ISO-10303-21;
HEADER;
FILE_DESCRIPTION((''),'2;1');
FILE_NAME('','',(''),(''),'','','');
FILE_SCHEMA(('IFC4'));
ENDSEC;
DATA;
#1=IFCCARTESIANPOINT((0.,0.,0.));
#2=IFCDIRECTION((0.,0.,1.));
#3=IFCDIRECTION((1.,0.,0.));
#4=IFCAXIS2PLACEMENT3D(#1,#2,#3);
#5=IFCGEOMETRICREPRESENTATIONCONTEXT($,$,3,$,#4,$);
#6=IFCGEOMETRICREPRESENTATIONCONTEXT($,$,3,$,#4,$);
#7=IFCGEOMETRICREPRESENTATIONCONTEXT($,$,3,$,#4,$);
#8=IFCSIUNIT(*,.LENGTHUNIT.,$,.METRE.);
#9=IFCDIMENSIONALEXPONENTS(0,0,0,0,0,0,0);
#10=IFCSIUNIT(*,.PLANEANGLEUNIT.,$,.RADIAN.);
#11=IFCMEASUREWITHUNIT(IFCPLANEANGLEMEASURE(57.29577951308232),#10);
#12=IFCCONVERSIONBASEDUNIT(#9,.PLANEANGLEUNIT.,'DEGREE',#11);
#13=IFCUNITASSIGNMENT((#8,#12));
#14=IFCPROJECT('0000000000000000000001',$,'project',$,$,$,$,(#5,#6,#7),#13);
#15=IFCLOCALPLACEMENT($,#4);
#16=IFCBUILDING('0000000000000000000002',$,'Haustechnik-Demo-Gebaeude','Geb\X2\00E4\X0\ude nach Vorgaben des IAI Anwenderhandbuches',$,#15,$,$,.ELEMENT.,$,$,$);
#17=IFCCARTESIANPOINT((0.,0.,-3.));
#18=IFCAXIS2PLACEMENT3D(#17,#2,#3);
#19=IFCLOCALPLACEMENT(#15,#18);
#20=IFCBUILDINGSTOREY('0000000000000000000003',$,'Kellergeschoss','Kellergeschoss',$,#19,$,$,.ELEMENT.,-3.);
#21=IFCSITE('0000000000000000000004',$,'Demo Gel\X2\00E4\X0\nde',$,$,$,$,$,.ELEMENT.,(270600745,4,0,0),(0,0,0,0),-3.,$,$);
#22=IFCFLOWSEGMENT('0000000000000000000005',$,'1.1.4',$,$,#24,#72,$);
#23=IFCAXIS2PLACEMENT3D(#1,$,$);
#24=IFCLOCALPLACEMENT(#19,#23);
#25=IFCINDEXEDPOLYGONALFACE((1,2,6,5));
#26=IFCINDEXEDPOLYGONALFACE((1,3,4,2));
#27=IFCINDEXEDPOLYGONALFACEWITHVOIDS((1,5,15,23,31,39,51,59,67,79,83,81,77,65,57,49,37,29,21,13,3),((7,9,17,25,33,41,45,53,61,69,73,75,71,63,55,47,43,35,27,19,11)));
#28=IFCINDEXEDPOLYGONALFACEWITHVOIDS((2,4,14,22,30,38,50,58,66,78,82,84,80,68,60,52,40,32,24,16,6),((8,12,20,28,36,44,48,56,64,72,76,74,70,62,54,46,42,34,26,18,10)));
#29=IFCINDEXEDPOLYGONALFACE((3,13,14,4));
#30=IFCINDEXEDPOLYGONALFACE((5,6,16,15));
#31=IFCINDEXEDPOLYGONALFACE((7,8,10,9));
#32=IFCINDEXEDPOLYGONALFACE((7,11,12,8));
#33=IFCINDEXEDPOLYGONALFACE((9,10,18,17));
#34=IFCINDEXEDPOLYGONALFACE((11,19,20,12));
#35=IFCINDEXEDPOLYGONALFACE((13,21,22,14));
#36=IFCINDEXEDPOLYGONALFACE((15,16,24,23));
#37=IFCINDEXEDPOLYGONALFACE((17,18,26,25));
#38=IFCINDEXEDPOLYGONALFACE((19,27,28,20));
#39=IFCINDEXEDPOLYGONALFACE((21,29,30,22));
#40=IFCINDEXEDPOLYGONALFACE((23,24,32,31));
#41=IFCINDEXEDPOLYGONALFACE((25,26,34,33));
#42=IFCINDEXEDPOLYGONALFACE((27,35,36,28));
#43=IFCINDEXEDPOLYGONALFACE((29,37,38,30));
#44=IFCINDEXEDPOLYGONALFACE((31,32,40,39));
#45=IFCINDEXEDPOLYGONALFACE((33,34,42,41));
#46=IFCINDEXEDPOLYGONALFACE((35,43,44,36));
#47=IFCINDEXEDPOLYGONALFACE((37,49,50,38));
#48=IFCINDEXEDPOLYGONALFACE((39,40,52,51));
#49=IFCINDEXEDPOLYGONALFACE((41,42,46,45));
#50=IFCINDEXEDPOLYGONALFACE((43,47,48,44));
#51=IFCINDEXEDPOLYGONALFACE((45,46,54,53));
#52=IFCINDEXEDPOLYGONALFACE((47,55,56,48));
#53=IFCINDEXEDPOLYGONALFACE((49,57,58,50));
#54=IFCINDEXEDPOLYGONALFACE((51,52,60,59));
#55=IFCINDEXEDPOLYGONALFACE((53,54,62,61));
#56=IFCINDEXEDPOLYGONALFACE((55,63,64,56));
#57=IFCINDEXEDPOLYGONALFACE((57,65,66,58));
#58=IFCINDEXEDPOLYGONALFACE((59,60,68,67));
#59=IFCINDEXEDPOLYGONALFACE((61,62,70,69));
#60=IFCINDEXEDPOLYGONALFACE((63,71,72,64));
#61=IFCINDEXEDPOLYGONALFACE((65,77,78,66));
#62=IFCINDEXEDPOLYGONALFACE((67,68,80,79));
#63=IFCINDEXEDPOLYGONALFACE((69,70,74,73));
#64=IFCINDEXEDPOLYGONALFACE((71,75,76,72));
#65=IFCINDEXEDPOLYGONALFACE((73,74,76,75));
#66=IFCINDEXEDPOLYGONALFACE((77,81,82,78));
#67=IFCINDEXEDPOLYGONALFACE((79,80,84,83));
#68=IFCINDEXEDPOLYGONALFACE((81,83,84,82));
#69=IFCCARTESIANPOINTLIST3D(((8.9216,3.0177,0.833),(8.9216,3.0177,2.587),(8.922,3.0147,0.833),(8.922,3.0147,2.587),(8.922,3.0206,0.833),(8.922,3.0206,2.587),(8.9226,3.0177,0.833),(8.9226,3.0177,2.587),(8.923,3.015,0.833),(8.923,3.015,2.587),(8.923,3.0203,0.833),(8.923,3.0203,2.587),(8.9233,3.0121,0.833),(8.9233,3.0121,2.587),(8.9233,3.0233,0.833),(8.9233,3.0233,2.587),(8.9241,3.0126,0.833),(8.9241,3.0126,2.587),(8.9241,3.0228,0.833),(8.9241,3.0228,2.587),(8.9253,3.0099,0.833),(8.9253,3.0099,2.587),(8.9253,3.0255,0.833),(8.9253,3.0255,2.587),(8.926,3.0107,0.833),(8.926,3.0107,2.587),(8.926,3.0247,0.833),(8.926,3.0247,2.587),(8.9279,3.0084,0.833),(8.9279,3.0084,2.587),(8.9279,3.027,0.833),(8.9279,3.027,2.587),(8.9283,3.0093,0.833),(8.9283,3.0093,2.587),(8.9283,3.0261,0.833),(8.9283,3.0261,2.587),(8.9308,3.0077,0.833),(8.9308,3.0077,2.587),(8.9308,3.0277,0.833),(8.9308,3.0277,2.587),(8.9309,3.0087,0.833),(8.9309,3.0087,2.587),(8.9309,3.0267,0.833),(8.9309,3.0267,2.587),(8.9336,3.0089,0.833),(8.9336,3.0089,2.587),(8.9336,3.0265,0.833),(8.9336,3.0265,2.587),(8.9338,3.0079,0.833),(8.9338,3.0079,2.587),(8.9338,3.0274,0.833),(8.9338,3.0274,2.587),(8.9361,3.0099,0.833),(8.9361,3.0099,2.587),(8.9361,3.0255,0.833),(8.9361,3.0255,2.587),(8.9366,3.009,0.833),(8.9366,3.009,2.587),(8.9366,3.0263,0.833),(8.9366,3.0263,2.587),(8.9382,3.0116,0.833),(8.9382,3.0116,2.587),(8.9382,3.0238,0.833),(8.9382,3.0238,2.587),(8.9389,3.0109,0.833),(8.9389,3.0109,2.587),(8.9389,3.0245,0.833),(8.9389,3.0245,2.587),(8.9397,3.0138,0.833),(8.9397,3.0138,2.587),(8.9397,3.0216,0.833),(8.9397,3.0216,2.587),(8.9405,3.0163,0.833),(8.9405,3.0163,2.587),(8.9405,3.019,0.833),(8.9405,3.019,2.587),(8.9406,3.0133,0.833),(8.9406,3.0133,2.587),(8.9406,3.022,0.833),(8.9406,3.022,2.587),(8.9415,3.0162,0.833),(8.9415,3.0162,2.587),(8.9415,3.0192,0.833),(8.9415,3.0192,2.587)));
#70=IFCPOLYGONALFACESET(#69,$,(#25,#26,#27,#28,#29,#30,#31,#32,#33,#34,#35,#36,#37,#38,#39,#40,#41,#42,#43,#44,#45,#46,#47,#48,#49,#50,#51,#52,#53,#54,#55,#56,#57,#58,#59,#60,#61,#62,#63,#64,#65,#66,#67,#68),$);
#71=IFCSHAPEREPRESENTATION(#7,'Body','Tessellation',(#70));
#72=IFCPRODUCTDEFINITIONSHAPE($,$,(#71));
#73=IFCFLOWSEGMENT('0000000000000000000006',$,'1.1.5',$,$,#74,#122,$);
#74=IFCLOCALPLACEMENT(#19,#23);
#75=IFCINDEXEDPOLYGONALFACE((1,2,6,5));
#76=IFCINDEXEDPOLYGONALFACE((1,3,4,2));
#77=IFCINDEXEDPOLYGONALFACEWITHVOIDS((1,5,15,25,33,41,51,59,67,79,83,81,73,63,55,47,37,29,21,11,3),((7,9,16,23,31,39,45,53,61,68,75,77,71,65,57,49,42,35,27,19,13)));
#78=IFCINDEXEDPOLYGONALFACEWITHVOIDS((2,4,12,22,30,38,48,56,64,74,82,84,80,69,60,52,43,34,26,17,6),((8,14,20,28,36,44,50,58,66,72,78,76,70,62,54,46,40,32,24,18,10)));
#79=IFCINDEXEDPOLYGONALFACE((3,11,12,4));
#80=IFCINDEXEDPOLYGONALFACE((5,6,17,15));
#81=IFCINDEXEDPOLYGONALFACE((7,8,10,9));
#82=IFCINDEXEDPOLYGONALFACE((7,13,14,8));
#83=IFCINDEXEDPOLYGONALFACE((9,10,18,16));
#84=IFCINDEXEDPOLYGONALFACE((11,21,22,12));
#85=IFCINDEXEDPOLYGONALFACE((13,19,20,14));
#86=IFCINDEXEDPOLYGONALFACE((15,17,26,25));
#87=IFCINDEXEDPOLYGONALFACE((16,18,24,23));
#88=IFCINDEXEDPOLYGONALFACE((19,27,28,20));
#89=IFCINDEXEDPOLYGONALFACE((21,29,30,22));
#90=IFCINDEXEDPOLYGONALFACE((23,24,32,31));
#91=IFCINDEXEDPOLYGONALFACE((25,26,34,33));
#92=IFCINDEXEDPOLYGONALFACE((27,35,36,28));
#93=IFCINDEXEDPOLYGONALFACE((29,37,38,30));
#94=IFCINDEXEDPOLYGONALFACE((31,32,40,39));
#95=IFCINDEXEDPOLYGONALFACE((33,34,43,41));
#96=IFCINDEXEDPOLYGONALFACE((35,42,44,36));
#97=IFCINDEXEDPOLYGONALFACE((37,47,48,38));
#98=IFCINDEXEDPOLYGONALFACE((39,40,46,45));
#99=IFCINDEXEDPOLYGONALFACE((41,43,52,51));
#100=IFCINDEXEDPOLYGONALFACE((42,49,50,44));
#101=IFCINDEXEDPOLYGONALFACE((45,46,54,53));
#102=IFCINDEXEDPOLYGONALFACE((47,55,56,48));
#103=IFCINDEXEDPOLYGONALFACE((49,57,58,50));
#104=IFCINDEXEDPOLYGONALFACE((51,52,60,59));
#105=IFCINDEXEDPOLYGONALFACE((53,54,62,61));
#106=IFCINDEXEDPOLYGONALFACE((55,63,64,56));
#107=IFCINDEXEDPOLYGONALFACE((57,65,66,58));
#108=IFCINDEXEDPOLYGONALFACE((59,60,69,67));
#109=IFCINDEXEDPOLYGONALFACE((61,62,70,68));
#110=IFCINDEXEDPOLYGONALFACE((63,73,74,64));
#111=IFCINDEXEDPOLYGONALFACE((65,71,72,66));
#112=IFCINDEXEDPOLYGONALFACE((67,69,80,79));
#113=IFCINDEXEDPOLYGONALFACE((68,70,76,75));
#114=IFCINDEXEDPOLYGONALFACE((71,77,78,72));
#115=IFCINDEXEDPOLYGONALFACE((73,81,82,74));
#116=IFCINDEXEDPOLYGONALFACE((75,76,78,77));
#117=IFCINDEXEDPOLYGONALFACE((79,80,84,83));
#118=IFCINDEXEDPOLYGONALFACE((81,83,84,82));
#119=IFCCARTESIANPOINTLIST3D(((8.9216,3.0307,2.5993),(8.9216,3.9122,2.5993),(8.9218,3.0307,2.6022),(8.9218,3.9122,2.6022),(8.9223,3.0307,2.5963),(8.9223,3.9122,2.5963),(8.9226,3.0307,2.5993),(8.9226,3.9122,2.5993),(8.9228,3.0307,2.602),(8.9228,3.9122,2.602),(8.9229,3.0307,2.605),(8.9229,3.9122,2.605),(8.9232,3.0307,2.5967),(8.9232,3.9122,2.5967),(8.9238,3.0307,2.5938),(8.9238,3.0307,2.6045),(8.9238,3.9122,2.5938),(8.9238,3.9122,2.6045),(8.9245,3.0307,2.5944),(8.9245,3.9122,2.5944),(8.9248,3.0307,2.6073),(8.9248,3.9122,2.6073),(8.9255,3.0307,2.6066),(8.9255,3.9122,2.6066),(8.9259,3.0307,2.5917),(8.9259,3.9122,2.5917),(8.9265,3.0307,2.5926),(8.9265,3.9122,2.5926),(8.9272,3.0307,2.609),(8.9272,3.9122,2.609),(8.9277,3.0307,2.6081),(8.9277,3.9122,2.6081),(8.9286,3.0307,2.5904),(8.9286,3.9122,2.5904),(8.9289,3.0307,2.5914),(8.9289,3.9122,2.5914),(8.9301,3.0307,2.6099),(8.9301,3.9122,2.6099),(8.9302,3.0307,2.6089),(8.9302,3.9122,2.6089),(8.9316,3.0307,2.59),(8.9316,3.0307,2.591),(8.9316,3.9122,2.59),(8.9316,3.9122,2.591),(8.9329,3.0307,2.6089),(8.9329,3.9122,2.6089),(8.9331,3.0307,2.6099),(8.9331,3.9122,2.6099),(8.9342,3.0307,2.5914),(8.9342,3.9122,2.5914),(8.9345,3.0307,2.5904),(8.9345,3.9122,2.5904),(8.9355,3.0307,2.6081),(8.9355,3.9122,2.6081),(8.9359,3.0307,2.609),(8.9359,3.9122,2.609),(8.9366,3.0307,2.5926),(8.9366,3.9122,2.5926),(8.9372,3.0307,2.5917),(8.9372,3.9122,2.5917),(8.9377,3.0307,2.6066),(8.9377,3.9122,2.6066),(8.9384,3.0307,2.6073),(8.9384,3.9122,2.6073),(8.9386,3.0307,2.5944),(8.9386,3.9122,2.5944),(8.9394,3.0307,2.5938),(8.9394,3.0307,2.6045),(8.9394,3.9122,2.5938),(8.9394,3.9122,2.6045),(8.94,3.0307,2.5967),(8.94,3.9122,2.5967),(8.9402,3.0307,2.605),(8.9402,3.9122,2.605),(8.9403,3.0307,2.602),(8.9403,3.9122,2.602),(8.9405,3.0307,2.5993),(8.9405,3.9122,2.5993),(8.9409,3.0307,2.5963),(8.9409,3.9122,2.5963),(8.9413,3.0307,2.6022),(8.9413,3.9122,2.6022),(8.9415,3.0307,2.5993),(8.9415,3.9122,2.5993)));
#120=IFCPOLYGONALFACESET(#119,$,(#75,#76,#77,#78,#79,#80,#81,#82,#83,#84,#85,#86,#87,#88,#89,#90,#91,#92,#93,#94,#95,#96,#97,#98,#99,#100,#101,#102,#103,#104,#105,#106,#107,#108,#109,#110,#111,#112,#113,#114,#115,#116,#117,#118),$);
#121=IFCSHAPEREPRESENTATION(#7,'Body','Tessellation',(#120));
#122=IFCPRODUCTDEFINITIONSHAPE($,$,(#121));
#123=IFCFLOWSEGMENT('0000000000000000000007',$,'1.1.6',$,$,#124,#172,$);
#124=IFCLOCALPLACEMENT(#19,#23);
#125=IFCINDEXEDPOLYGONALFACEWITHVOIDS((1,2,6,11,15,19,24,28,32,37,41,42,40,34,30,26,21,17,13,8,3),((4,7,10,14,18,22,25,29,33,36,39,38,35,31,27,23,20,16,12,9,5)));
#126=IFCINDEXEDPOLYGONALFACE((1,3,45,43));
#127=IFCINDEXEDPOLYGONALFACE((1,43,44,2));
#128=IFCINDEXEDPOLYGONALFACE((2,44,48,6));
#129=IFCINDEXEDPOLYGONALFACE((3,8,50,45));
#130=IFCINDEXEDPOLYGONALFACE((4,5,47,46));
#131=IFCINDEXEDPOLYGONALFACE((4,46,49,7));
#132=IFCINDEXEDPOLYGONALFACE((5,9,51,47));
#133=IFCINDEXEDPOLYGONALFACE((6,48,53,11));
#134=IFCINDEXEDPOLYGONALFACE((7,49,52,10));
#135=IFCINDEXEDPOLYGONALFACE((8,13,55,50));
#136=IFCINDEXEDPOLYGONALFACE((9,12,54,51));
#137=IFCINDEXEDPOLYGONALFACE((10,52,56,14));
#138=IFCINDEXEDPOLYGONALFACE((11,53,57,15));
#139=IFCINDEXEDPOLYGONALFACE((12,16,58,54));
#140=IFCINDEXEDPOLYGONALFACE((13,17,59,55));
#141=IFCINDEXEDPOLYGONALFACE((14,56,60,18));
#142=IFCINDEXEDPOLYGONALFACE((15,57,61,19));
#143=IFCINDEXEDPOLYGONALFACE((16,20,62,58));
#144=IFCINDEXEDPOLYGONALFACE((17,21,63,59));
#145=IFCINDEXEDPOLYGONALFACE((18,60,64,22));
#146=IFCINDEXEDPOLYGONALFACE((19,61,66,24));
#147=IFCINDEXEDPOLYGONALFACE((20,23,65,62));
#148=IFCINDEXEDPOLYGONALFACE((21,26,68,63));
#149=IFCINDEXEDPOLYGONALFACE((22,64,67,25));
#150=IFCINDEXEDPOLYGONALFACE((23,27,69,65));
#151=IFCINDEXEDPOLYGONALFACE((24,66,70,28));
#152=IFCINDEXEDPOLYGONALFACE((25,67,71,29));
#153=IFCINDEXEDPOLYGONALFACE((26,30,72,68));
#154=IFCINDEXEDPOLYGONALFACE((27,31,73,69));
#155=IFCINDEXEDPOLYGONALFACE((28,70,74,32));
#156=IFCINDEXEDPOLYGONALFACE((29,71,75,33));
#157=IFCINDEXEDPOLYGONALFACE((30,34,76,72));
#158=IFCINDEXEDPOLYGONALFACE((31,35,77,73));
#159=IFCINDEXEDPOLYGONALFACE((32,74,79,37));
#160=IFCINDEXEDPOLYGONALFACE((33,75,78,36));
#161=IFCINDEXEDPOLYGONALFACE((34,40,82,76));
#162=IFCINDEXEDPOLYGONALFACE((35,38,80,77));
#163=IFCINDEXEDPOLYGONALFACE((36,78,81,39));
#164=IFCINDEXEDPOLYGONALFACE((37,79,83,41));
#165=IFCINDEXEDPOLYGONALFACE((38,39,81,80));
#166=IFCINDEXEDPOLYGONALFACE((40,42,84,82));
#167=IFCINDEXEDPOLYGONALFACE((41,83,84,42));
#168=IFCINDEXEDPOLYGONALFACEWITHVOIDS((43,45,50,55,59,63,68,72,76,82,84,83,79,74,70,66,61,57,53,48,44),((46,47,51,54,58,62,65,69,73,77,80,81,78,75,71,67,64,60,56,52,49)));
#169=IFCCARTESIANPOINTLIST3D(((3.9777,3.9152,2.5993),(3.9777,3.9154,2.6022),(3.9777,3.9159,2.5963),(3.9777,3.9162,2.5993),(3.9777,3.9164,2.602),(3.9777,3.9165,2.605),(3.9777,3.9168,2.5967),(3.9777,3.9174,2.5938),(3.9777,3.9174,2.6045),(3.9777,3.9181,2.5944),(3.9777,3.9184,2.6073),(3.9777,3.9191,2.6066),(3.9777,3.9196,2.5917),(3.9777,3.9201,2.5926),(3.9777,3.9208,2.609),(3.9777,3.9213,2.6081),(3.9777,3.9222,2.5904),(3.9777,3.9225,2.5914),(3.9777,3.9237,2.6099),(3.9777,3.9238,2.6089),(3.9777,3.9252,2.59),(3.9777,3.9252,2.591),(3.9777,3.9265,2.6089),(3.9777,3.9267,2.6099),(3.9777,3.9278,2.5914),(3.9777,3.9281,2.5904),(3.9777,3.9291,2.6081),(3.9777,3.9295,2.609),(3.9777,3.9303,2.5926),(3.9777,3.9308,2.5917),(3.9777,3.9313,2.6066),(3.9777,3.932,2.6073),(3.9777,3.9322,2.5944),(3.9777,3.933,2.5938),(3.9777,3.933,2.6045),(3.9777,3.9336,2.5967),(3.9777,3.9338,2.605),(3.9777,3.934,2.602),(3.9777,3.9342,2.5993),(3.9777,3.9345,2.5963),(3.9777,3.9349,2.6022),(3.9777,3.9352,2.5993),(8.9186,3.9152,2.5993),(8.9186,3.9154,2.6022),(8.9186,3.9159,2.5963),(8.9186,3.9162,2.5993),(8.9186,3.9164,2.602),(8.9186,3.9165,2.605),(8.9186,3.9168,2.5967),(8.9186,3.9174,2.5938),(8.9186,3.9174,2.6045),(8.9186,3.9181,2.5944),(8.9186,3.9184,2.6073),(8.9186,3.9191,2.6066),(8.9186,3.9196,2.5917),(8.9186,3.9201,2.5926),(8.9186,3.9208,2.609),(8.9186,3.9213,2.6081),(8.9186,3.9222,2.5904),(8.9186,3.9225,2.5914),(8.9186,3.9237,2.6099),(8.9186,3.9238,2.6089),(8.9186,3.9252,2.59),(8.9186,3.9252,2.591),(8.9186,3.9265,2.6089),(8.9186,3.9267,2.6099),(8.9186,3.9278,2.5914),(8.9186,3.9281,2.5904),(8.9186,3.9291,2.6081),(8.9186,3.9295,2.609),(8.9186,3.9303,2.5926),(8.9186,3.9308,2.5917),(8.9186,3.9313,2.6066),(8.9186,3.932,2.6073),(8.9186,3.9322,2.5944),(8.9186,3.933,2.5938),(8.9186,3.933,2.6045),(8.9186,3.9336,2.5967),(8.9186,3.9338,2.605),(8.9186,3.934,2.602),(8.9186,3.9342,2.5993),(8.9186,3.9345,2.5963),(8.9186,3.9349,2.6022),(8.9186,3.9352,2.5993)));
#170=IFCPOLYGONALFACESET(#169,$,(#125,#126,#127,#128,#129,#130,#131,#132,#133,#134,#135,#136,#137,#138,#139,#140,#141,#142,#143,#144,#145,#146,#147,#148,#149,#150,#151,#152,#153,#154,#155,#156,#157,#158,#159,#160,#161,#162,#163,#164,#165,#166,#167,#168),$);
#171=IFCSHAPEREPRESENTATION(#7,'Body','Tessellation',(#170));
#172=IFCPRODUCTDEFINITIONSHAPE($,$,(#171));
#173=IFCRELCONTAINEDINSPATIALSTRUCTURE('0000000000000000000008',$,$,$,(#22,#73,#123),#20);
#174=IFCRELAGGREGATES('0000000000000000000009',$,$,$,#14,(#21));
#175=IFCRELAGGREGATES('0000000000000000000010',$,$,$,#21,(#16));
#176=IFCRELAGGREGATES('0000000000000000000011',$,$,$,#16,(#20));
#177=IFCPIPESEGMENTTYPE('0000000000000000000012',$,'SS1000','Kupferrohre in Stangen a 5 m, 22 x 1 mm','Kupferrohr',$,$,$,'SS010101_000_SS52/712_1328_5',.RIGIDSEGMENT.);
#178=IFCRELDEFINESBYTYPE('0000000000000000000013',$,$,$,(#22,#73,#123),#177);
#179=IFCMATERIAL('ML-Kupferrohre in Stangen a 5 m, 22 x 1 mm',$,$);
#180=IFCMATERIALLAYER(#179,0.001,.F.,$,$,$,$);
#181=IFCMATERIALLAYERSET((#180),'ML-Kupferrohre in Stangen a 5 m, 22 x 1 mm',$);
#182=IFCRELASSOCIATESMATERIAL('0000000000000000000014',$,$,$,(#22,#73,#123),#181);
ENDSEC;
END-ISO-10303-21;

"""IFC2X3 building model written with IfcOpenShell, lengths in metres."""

from ifc_helpers import new_model, entity, si_unit, converted_unit, frame, origin_with_axes, origin_2d_with_axis, place, context, project, spatial, hollow_circle, extrude, material, layer, layer_set, layer_usage, type_object, element, save


model = new_model("IFC2X3")

# Units and contexts
context_of_model_1 = context(None, 3, world=origin_with_axes())
context_of_model_2 = context(None, 3, world=origin_with_axes())
context_of_model_3 = context(None, 3, world=origin_with_axes())
ifc_project = project(units=[si_unit("LENGTHUNIT", "METRE"), converted_unit("PLANEANGLEUNIT", "DEGREE", entity("IfcPlaneAngleMeasure", 57.29577951308232), si_unit("PLANEANGLEUNIT", "RADIAN"), dimensions=[0, 0, 0, 0, 0, 0, 0])], contexts=[context_of_model_1, context_of_model_2, context_of_model_3])

# Site, building, storey
site = spatial("IfcSite", under=ifc_project, Name="Demo Gelände", CompositionType="ELEMENT", RefLatitude=(270600745, 4, 0, 0), RefLongitude=(0, 0, 0, 0), RefElevation=-3.0)
building_placement = place(None, origin_with_axes())
building = spatial("IfcBuilding", under=site, at=building_placement, Name="Haustechnik-Demo-Gebaeude", Description="Gebäude nach Vorgaben des IAI Anwenderhandbuches", CompositionType="ELEMENT")
storey_placement = place(building_placement, frame((0.0, 0.0, -3.0), z_axis=(0.0, 0.0, 1.0), x_axis=(1.0, 0.0, 0.0)))
storey = spatial("IfcBuildingStorey", under=building, at=storey_placement, Name="Kellergeschoss", Description="Kellergeschoss", CompositionType="ELEMENT", Elevation=-3.0)

# Flow segments
ifc_material = material(Name="ML-Kupferrohre in Stangen a 5 m, 22 x 1 mm")
ifc_layer = layer(ifc_material, 0.001, ventilated=False)
ifc_layer_set = layer_set([ifc_layer], Name="ML-Kupferrohre in Stangen a 5 m, 22 x 1 mm")
ifc_layer_usage = layer_usage(ifc_layer_set, "AXIS2", "POSITIVE", 0.0)
pipe_segment_type_1 = type_object("IfcPipeSegmentType", Name="SS1000", Description="Kupferrohre in Stangen a 5 m, 22 x 1 mm", ApplicableOccurrence="Kupferrohr", ElementType="SS010101_000_SS52/712_1328_5", PredefinedType="RIGIDSEGMENT")
flow_segment_1_placement = place(storey_placement, frame((8.9316, 3.0177, 0.833), z_axis=(0.0, 0.0, 1.0), x_axis=(-1.0, 0.0, 0.0)))
element("IfcFlowSegment", 1, at=flow_segment_1_placement, inside=storey, type_object=pipe_segment_type_1, material=ifc_layer_usage, Name="1.1.4", context=context_of_model_3, shape_type="SweptSolid", body=[
    extrude(hollow_circle(Radius=0.01, WallThickness=0.001, at=origin_2d_with_axis()), origin_with_axes(), (0.0, 0.0, 1.0), 1.754),
])
flow_segment_2_placement = place(storey_placement, frame((8.9316, 3.0307, 2.6), z_axis=(0.0, 1.0, 0.0), x_axis=(0.0, 0.0, -1.0)))
element("IfcFlowSegment", 2, at=flow_segment_2_placement, inside=storey, type_object=pipe_segment_type_1, material=ifc_layer_usage, Name="1.1.5", context=context_of_model_3, shape_type="SweptSolid", body=[
    extrude(hollow_circle(Radius=0.01, WallThickness=0.001, at=origin_2d_with_axis()), origin_with_axes(), (0.0, 0.0, 1.0), 0.8815),
])
flow_segment_3_placement = place(storey_placement, frame((8.9186, 3.9252, 2.6), z_axis=(-1.0, 0.0, 0.0), x_axis=(0.0, 0.0, -1.0)))
element("IfcFlowSegment", 3, at=flow_segment_3_placement, inside=storey, type_object=pipe_segment_type_1, material=ifc_layer_usage, Name="1.1.6", context=context_of_model_3, shape_type="SweptSolid", body=[
    extrude(hollow_circle(Radius=0.01, WallThickness=0.001, at=origin_2d_with_axis()), origin_with_axes(), (0.0, 0.0, 1.0), 4.9409),
])

save(model, "model.ifc")
